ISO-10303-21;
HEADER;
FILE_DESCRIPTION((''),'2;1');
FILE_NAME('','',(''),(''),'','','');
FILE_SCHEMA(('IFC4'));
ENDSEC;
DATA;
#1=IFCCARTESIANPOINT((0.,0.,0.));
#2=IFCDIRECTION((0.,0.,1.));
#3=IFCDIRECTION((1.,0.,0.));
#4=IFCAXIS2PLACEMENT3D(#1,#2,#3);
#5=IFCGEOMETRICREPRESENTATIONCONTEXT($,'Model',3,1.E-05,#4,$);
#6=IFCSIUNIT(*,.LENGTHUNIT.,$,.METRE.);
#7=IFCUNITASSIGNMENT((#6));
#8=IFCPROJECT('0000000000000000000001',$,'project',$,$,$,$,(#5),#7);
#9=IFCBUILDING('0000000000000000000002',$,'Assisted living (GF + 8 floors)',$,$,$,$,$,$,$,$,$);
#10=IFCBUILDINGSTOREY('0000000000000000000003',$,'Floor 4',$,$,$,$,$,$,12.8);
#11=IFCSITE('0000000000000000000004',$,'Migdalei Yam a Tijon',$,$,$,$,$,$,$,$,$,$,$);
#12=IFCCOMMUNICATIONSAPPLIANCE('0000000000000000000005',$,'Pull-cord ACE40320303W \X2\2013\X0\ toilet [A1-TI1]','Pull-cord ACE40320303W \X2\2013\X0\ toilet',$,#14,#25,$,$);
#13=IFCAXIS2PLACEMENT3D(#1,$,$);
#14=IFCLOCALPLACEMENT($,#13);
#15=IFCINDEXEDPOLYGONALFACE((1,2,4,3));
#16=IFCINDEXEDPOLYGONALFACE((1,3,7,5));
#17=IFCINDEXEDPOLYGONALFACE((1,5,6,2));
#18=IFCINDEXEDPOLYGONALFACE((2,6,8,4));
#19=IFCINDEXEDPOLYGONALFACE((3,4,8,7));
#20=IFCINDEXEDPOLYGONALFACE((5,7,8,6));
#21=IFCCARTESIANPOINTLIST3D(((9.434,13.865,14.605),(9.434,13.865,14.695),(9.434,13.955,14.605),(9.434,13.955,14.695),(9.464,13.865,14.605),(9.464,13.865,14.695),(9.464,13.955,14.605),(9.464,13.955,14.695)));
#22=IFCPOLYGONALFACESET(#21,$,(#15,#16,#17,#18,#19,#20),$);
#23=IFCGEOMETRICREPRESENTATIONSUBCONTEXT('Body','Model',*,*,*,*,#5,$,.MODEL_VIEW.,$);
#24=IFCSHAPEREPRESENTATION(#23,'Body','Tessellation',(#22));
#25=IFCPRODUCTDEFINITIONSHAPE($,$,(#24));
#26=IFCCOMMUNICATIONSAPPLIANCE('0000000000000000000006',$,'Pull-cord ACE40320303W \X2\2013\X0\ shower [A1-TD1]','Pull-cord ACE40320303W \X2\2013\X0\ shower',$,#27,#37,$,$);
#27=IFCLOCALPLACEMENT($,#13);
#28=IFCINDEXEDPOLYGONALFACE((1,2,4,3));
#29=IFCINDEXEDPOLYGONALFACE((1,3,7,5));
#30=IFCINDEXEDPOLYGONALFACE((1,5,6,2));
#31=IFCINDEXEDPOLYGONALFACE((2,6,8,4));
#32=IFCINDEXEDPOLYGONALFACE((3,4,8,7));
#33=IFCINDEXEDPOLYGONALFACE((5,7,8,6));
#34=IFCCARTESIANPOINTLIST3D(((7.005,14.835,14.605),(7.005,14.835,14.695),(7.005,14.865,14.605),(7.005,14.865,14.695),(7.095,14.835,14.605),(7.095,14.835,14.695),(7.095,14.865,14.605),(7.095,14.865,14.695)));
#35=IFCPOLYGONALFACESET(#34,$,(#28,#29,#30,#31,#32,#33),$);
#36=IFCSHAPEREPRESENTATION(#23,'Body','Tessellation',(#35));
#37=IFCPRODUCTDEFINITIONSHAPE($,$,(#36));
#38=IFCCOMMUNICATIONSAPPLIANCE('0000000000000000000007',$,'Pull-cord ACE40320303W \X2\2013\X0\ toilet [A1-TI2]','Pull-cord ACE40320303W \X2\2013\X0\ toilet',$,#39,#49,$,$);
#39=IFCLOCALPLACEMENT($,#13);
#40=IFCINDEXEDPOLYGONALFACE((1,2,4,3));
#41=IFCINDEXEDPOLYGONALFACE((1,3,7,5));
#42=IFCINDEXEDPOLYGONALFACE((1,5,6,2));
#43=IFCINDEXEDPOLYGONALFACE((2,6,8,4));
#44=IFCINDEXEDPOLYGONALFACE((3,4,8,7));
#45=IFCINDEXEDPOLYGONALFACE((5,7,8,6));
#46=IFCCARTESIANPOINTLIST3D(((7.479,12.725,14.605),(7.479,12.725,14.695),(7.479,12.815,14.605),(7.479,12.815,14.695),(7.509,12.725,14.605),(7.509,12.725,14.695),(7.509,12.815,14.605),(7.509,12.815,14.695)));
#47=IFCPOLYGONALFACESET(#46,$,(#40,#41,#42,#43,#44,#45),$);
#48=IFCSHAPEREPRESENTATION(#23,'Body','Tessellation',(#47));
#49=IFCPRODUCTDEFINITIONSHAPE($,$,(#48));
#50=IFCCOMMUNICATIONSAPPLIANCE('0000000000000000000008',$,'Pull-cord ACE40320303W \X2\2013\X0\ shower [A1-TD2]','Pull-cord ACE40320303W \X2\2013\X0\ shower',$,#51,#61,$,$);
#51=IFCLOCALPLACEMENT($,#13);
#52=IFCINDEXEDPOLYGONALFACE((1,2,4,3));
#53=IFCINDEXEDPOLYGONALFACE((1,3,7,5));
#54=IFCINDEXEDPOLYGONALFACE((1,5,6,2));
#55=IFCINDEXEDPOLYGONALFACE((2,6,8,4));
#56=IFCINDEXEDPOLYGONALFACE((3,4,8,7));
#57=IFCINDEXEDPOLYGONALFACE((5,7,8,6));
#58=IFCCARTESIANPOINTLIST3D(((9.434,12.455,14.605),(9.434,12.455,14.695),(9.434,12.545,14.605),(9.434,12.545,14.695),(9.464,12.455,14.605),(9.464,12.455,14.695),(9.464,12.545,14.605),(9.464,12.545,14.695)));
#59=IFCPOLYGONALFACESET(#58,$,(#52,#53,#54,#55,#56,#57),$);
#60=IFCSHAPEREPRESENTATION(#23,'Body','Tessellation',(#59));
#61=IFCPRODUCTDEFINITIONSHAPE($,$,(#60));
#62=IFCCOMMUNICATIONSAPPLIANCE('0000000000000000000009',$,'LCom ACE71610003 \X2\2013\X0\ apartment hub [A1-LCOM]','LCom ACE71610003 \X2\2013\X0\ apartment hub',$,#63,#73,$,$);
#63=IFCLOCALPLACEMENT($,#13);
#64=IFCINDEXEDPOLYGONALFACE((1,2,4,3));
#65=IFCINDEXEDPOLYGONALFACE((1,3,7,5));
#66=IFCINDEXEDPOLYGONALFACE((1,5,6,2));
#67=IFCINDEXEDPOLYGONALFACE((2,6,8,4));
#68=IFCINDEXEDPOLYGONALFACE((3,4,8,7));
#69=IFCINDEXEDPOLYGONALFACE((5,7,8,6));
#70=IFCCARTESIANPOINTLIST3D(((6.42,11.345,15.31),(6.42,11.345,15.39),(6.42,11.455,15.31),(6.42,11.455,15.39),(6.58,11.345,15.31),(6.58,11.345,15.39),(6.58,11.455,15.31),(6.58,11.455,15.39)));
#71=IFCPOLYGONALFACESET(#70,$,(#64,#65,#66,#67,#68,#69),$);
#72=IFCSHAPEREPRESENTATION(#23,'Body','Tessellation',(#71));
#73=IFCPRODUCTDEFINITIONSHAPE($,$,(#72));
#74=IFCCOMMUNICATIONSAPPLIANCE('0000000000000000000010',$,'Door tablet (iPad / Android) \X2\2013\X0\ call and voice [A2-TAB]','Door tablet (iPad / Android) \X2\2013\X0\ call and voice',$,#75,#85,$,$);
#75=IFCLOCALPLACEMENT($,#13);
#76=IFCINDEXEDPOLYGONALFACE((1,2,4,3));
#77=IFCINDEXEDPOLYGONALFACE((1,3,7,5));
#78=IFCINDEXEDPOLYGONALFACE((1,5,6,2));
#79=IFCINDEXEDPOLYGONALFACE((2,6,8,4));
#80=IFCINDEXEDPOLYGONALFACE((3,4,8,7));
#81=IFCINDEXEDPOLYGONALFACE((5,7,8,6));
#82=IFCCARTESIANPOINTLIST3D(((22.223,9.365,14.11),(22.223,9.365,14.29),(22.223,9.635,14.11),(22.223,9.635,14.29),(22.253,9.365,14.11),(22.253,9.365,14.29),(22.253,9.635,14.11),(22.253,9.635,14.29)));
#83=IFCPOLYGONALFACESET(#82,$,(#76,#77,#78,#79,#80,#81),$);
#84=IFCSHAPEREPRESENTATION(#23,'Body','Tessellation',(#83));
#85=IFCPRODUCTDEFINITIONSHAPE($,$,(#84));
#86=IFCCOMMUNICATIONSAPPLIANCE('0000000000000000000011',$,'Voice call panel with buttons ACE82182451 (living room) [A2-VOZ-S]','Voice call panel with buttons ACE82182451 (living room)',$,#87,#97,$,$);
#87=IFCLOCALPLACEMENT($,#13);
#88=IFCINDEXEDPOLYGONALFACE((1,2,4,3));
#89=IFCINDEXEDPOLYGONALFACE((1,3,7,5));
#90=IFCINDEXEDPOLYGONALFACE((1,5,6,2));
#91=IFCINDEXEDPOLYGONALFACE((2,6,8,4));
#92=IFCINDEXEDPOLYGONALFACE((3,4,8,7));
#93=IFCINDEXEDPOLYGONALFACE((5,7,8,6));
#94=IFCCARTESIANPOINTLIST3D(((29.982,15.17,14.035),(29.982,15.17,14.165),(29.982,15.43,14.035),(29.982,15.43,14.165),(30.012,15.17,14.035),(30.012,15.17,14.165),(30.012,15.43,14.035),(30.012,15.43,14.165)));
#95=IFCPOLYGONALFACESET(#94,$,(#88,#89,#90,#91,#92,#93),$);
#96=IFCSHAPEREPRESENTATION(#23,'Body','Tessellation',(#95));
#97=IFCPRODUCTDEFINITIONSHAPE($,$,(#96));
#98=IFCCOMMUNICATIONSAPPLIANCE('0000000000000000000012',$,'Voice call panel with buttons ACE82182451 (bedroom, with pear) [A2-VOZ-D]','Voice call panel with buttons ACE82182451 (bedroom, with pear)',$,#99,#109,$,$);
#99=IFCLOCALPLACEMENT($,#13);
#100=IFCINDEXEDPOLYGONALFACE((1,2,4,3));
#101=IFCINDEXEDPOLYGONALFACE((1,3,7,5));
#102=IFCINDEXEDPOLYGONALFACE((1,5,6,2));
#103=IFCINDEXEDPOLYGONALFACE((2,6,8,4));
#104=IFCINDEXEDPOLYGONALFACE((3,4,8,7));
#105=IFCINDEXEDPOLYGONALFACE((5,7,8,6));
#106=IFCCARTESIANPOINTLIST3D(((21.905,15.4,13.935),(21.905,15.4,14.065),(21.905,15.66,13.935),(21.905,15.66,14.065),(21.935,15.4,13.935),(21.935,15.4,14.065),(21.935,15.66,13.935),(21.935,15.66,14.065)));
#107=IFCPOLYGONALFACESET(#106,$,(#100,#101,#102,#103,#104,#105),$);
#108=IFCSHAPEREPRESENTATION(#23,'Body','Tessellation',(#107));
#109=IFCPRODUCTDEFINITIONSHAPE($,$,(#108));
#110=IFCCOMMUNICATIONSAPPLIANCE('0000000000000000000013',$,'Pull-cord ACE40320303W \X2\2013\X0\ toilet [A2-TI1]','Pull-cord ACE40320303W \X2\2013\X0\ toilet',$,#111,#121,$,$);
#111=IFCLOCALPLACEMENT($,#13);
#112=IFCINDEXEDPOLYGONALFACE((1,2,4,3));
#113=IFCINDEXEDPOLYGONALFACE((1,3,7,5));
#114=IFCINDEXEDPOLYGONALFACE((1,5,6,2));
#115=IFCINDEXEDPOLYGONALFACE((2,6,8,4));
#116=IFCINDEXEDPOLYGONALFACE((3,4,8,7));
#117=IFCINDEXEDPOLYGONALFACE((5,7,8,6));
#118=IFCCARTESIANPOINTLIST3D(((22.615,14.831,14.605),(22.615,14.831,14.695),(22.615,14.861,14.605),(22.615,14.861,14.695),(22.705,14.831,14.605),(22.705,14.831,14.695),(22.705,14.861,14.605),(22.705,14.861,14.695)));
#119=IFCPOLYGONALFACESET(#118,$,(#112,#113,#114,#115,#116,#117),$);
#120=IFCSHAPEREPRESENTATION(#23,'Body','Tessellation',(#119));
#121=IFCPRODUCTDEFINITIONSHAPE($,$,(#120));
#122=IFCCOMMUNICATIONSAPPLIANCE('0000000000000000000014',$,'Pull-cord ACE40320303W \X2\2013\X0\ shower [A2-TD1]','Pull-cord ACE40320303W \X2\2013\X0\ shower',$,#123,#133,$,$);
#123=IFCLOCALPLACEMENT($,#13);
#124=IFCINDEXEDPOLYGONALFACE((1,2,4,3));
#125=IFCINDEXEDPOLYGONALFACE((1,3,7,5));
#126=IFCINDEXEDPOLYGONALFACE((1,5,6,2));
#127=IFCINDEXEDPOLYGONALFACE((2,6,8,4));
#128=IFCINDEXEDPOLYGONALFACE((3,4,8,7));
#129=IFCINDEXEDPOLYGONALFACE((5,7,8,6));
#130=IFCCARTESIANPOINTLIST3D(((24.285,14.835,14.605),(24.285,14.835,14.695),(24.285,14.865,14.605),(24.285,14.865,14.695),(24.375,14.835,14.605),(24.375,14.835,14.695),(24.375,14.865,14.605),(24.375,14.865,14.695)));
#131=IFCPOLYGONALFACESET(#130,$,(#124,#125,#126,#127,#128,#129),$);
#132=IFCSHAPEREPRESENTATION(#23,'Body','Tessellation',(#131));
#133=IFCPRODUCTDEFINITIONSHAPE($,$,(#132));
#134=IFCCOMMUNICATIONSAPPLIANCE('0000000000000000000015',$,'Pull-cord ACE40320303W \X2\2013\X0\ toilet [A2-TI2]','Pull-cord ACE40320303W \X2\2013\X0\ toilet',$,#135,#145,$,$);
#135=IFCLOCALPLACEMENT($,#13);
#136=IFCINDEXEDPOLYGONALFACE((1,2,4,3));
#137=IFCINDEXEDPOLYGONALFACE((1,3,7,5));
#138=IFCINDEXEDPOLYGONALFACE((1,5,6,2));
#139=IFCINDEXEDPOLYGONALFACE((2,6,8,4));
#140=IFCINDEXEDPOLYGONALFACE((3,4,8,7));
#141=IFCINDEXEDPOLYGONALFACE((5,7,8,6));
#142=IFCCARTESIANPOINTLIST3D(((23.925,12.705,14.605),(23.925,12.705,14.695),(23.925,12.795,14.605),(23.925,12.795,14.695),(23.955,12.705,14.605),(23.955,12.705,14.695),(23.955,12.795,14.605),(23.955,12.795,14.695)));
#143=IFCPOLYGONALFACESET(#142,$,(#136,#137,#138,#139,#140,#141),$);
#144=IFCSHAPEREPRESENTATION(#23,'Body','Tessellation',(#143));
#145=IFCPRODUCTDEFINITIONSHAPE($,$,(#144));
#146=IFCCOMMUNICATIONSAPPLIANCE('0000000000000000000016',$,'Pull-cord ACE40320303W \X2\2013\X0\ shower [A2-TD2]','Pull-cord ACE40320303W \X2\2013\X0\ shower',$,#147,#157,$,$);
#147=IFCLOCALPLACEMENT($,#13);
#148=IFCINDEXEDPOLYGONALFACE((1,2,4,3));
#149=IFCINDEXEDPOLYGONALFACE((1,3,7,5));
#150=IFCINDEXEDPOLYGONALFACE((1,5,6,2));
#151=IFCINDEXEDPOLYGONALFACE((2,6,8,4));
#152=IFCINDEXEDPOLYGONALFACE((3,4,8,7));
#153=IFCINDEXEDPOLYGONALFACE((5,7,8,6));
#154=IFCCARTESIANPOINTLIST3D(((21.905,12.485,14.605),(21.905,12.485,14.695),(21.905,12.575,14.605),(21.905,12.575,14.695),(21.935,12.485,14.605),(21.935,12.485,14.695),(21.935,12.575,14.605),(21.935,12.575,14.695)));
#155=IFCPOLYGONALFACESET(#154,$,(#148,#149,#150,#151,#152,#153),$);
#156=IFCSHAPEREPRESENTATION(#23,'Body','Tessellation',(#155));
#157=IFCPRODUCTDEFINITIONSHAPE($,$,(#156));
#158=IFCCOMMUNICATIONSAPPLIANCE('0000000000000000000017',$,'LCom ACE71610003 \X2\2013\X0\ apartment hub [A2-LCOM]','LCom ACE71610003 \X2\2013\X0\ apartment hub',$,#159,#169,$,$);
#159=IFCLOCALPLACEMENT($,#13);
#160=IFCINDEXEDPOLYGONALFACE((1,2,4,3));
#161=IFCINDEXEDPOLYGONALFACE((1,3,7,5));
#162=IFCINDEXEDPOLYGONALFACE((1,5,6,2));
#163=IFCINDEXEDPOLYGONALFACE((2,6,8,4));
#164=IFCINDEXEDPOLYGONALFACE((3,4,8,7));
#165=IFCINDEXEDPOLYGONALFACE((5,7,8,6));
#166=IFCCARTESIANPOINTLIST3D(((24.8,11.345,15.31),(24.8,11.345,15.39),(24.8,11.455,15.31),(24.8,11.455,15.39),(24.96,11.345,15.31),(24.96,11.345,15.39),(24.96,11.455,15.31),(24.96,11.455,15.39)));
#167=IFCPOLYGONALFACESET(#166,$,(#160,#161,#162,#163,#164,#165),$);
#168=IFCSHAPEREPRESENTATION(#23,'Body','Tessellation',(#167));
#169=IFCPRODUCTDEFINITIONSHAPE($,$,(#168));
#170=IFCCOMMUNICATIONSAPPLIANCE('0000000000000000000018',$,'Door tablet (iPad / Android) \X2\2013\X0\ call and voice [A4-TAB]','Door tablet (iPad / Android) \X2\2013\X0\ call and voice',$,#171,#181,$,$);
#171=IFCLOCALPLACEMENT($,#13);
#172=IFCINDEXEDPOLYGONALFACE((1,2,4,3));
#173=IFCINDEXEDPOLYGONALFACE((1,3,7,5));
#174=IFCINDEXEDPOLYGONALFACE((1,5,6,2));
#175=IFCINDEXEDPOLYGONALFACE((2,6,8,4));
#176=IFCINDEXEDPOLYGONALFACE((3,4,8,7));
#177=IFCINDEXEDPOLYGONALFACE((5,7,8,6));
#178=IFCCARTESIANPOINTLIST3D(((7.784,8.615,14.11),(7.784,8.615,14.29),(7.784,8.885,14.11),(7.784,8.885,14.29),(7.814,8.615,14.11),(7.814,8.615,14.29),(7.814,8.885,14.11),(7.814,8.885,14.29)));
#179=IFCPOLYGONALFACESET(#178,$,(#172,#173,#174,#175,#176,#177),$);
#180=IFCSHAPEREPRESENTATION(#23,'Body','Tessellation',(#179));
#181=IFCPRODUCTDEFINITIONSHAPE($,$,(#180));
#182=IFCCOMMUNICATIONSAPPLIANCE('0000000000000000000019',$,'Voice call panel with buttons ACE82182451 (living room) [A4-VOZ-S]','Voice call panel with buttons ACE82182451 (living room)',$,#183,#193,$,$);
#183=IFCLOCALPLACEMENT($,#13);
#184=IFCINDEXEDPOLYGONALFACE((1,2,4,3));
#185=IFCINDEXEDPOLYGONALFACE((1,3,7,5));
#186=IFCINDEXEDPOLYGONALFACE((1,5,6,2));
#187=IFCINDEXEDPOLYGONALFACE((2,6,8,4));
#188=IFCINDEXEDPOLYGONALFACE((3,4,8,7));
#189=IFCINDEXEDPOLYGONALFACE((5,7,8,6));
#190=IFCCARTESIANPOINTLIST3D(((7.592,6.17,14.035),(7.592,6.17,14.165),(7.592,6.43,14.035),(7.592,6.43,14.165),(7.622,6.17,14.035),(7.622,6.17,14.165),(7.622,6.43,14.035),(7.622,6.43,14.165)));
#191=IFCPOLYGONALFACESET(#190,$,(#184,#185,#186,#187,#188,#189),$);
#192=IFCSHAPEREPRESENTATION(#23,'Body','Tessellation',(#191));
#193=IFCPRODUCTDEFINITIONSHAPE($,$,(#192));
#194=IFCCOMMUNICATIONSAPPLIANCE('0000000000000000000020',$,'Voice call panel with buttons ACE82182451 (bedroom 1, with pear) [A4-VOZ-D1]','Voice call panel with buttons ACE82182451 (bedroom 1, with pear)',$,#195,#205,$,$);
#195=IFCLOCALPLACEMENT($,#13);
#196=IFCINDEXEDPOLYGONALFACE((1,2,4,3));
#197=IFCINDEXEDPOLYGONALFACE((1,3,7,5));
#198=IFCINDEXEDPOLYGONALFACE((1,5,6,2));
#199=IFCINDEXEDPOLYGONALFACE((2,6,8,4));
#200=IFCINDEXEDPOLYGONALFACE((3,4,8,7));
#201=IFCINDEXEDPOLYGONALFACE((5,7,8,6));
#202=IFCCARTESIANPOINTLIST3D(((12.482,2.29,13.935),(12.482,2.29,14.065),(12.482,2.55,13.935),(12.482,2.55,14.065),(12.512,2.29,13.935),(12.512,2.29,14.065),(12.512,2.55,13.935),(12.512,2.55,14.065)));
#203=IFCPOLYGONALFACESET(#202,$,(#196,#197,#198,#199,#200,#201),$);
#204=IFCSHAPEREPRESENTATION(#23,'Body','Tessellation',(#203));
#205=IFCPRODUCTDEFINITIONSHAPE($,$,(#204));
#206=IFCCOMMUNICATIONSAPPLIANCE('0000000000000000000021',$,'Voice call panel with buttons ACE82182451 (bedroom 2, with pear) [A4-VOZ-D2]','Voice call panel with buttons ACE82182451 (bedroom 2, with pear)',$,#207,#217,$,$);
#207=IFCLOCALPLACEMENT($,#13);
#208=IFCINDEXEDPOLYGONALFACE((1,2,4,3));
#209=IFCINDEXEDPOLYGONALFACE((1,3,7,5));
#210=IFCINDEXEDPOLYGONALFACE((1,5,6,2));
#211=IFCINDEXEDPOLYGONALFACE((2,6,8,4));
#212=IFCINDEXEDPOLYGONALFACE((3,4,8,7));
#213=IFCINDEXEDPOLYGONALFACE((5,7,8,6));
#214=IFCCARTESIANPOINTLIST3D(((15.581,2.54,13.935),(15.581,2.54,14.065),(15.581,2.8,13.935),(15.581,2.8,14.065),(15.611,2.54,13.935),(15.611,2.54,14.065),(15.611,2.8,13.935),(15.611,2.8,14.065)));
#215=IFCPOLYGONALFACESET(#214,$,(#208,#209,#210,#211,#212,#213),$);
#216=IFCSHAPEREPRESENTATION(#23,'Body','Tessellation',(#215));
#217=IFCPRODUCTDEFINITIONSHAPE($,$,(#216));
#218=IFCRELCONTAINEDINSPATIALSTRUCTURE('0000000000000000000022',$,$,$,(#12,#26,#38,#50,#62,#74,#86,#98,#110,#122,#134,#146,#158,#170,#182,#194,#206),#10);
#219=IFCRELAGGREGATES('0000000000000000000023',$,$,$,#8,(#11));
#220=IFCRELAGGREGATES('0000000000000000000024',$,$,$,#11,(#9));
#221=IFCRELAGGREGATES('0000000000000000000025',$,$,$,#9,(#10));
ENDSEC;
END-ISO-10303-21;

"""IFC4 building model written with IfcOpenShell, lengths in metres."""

from ifc_helpers import new_model, si_unit, frame, origin_with_axes, context, subcontext, project, spatial, line, indexed_curve, outline, extrude, element, save


model = new_model("IFC4")

# Units and contexts
model_context = context("Model", 3, precision=1e-05, world=origin_with_axes())
body_context = subcontext(model_context, "Body", "Model", "MODEL_VIEW")
ifc_project = project(units=[si_unit("LENGTHUNIT", "METRE")], contexts=[model_context])

# Site, building, storey
site = spatial("IfcSite", under=ifc_project, Name="Migdalei Yam a Tijon")
building = spatial("IfcBuilding", under=site, Name="Assisted living (GF + 8 floors)")
storey = spatial("IfcBuildingStorey", under=building, Name="Floor 4", Elevation=12.8)

# Communications appliances
element("IfcCommunicationsAppliance", 1, inside=storey, Name="Pull-cord ACE40320303W – toilet [A1-TI1]", Description="Pull-cord ACE40320303W – toilet", context=body_context, shape_type="SweptSolid", body=[
    extrude(outline(indexed_curve([(0.0, 0.0), (0.03, 0.0), (0.03, 0.09), (0.0, 0.09)], segments=[line(1, 2, 3, 4, 1)])), frame((9.434, 13.865, 14.605), z_axis=(0.0, 0.0, 1.0), x_axis=(1.0, 0.0, 0.0)), (0.0, 0.0, 1.0), 0.09),
])
element("IfcCommunicationsAppliance", 2, inside=storey, Name="Pull-cord ACE40320303W – shower [A1-TD1]", Description="Pull-cord ACE40320303W – shower", context=body_context, shape_type="SweptSolid", body=[
    extrude(outline(indexed_curve([(0.0, 0.0), (0.09, 0.0), (0.09, 0.03), (0.0, 0.03)], segments=[line(1, 2, 3, 4, 1)])), frame((7.005, 14.835, 14.605), z_axis=(0.0, 0.0, 1.0), x_axis=(1.0, 0.0, 0.0)), (0.0, 0.0, 1.0), 0.09),
])
element("IfcCommunicationsAppliance", 3, inside=storey, Name="Pull-cord ACE40320303W – toilet [A1-TI2]", Description="Pull-cord ACE40320303W – toilet", context=body_context, shape_type="SweptSolid", body=[
    extrude(outline(indexed_curve([(0.0, 0.0), (0.03, 0.0), (0.03, 0.09), (0.0, 0.09)], segments=[line(1, 2, 3, 4, 1)])), frame((7.479, 12.725, 14.605), z_axis=(0.0, 0.0, 1.0), x_axis=(1.0, 0.0, 0.0)), (0.0, 0.0, 1.0), 0.09),
])
element("IfcCommunicationsAppliance", 4, inside=storey, Name="Pull-cord ACE40320303W – shower [A1-TD2]", Description="Pull-cord ACE40320303W – shower", context=body_context, shape_type="SweptSolid", body=[
    extrude(outline(indexed_curve([(0.0, 0.0), (0.03, 0.0), (0.03, 0.09), (0.0, 0.09)], segments=[line(1, 2, 3, 4, 1)])), frame((9.434, 12.455, 14.605), z_axis=(0.0, 0.0, 1.0), x_axis=(1.0, 0.0, 0.0)), (0.0, 0.0, 1.0), 0.09),
])
element("IfcCommunicationsAppliance", 5, inside=storey, Name="LCom ACE71610003 – apartment hub [A1-LCOM]", Description="LCom ACE71610003 – apartment hub", context=body_context, shape_type="SweptSolid", body=[
    extrude(outline(indexed_curve([(0.0, 0.0), (0.16, 0.0), (0.16, 0.11), (0.0, 0.11)], segments=[line(1, 2, 3, 4, 1)])), frame((6.42, 11.345, 15.31), z_axis=(0.0, 0.0, 1.0), x_axis=(1.0, 0.0, 0.0)), (0.0, 0.0, 1.0), 0.08),
])
element("IfcCommunicationsAppliance", 6, inside=storey, Name="Door tablet (iPad / Android) – call and voice [A2-TAB]", Description="Door tablet (iPad / Android) – call and voice", context=body_context, shape_type="SweptSolid", body=[
    extrude(outline(indexed_curve([(0.0, 0.0), (0.03, 0.0), (0.03, 0.27), (0.0, 0.27)], segments=[line(1, 2, 3, 4, 1)])), frame((22.223, 9.365, 14.11), z_axis=(0.0, 0.0, 1.0), x_axis=(1.0, 0.0, 0.0)), (0.0, 0.0, 1.0), 0.18),
])
element("IfcCommunicationsAppliance", 7, inside=storey, Name="Voice call panel with buttons ACE82182451 (living room) [A2-VOZ-S]", Description="Voice call panel with buttons ACE82182451 (living room)", context=body_context, shape_type="SweptSolid", body=[
    extrude(outline(indexed_curve([(0.0, 0.0), (0.03, 0.0), (0.03, 0.26), (0.0, 0.26)], segments=[line(1, 2, 3, 4, 1)])), frame((29.982, 15.17, 14.035), z_axis=(0.0, 0.0, 1.0), x_axis=(1.0, 0.0, 0.0)), (0.0, 0.0, 1.0), 0.13),
])
element("IfcCommunicationsAppliance", 8, inside=storey, Name="Voice call panel with buttons ACE82182451 (bedroom, with pear) [A2-VOZ-D]", Description="Voice call panel with buttons ACE82182451 (bedroom, with pear)", context=body_context, shape_type="SweptSolid", body=[
    extrude(outline(indexed_curve([(0.0, 0.0), (0.03, 0.0), (0.03, 0.26), (0.0, 0.26)], segments=[line(1, 2, 3, 4, 1)])), frame((21.905, 15.4, 13.935), z_axis=(0.0, 0.0, 1.0), x_axis=(1.0, 0.0, 0.0)), (0.0, 0.0, 1.0), 0.13),
])
element("IfcCommunicationsAppliance", 9, inside=storey, Name="Pull-cord ACE40320303W – toilet [A2-TI1]", Description="Pull-cord ACE40320303W – toilet", context=body_context, shape_type="SweptSolid", body=[
    extrude(outline(indexed_curve([(0.0, 0.0), (0.09, 0.0), (0.09, 0.03), (0.0, 0.03)], segments=[line(1, 2, 3, 4, 1)])), frame((22.615, 14.831, 14.605), z_axis=(0.0, 0.0, 1.0), x_axis=(1.0, 0.0, 0.0)), (0.0, 0.0, 1.0), 0.09),
])
element("IfcCommunicationsAppliance", 10, inside=storey, Name="Pull-cord ACE40320303W – shower [A2-TD1]", Description="Pull-cord ACE40320303W – shower", context=body_context, shape_type="SweptSolid", body=[
    extrude(outline(indexed_curve([(0.0, 0.0), (0.09, 0.0), (0.09, 0.03), (0.0, 0.03)], segments=[line(1, 2, 3, 4, 1)])), frame((24.285, 14.835, 14.605), z_axis=(0.0, 0.0, 1.0), x_axis=(1.0, 0.0, 0.0)), (0.0, 0.0, 1.0), 0.09),
])
element("IfcCommunicationsAppliance", 11, inside=storey, Name="Pull-cord ACE40320303W – toilet [A2-TI2]", Description="Pull-cord ACE40320303W – toilet", context=body_context, shape_type="SweptSolid", body=[
    extrude(outline(indexed_curve([(0.0, 0.0), (0.03, 0.0), (0.03, 0.09), (0.0, 0.09)], segments=[line(1, 2, 3, 4, 1)])), frame((23.925, 12.705, 14.605), z_axis=(0.0, 0.0, 1.0), x_axis=(1.0, 0.0, 0.0)), (0.0, 0.0, 1.0), 0.09),
])
element("IfcCommunicationsAppliance", 12, inside=storey, Name="Pull-cord ACE40320303W – shower [A2-TD2]", Description="Pull-cord ACE40320303W – shower", context=body_context, shape_type="SweptSolid", body=[
    extrude(outline(indexed_curve([(0.0, 0.0), (0.03, 0.0), (0.03, 0.09), (0.0, 0.09)], segments=[line(1, 2, 3, 4, 1)])), frame((21.905, 12.485, 14.605), z_axis=(0.0, 0.0, 1.0), x_axis=(1.0, 0.0, 0.0)), (0.0, 0.0, 1.0), 0.09),
])
element("IfcCommunicationsAppliance", 13, inside=storey, Name="LCom ACE71610003 – apartment hub [A2-LCOM]", Description="LCom ACE71610003 – apartment hub", context=body_context, shape_type="SweptSolid", body=[
    extrude(outline(indexed_curve([(0.0, 0.0), (0.16, 0.0), (0.16, 0.11), (0.0, 0.11)], segments=[line(1, 2, 3, 4, 1)])), frame((24.8, 11.345, 15.31), z_axis=(0.0, 0.0, 1.0), x_axis=(1.0, 0.0, 0.0)), (0.0, 0.0, 1.0), 0.08),
])
element("IfcCommunicationsAppliance", 14, inside=storey, Name="Door tablet (iPad / Android) – call and voice [A4-TAB]", Description="Door tablet (iPad / Android) – call and voice", context=body_context, shape_type="SweptSolid", body=[
    extrude(outline(indexed_curve([(0.0, 0.0), (0.03, 0.0), (0.03, 0.27), (0.0, 0.27)], segments=[line(1, 2, 3, 4, 1)])), frame((7.784, 8.615, 14.11), z_axis=(0.0, 0.0, 1.0), x_axis=(1.0, 0.0, 0.0)), (0.0, 0.0, 1.0), 0.18),
])
element("IfcCommunicationsAppliance", 15, inside=storey, Name="Voice call panel with buttons ACE82182451 (living room) [A4-VOZ-S]", Description="Voice call panel with buttons ACE82182451 (living room)", context=body_context, shape_type="SweptSolid", body=[
    extrude(outline(indexed_curve([(0.0, 0.0), (0.03, 0.0), (0.03, 0.26), (0.0, 0.26)], segments=[line(1, 2, 3, 4, 1)])), frame((7.592, 6.17, 14.035), z_axis=(0.0, 0.0, 1.0), x_axis=(1.0, 0.0, 0.0)), (0.0, 0.0, 1.0), 0.13),
])
element("IfcCommunicationsAppliance", 16, inside=storey, Name="Voice call panel with buttons ACE82182451 (bedroom 1, with pear) [A4-VOZ-D1]", Description="Voice call panel with buttons ACE82182451 (bedroom 1, with pear)", context=body_context, shape_type="SweptSolid", body=[
    extrude(outline(indexed_curve([(0.0, 0.0), (0.03, 0.0), (0.03, 0.26), (0.0, 0.26)], segments=[line(1, 2, 3, 4, 1)])), frame((12.482, 2.29, 13.935), z_axis=(0.0, 0.0, 1.0), x_axis=(1.0, 0.0, 0.0)), (0.0, 0.0, 1.0), 0.13),
])
element("IfcCommunicationsAppliance", 17, inside=storey, Name="Voice call panel with buttons ACE82182451 (bedroom 2, with pear) [A4-VOZ-D2]", Description="Voice call panel with buttons ACE82182451 (bedroom 2, with pear)", context=body_context, shape_type="SweptSolid", body=[
    extrude(outline(indexed_curve([(0.0, 0.0), (0.03, 0.0), (0.03, 0.26), (0.0, 0.26)], segments=[line(1, 2, 3, 4, 1)])), frame((15.581, 2.54, 13.935), z_axis=(0.0, 0.0, 1.0), x_axis=(1.0, 0.0, 0.0)), (0.0, 0.0, 1.0), 0.13),
])

save(model, "model.ifc")
